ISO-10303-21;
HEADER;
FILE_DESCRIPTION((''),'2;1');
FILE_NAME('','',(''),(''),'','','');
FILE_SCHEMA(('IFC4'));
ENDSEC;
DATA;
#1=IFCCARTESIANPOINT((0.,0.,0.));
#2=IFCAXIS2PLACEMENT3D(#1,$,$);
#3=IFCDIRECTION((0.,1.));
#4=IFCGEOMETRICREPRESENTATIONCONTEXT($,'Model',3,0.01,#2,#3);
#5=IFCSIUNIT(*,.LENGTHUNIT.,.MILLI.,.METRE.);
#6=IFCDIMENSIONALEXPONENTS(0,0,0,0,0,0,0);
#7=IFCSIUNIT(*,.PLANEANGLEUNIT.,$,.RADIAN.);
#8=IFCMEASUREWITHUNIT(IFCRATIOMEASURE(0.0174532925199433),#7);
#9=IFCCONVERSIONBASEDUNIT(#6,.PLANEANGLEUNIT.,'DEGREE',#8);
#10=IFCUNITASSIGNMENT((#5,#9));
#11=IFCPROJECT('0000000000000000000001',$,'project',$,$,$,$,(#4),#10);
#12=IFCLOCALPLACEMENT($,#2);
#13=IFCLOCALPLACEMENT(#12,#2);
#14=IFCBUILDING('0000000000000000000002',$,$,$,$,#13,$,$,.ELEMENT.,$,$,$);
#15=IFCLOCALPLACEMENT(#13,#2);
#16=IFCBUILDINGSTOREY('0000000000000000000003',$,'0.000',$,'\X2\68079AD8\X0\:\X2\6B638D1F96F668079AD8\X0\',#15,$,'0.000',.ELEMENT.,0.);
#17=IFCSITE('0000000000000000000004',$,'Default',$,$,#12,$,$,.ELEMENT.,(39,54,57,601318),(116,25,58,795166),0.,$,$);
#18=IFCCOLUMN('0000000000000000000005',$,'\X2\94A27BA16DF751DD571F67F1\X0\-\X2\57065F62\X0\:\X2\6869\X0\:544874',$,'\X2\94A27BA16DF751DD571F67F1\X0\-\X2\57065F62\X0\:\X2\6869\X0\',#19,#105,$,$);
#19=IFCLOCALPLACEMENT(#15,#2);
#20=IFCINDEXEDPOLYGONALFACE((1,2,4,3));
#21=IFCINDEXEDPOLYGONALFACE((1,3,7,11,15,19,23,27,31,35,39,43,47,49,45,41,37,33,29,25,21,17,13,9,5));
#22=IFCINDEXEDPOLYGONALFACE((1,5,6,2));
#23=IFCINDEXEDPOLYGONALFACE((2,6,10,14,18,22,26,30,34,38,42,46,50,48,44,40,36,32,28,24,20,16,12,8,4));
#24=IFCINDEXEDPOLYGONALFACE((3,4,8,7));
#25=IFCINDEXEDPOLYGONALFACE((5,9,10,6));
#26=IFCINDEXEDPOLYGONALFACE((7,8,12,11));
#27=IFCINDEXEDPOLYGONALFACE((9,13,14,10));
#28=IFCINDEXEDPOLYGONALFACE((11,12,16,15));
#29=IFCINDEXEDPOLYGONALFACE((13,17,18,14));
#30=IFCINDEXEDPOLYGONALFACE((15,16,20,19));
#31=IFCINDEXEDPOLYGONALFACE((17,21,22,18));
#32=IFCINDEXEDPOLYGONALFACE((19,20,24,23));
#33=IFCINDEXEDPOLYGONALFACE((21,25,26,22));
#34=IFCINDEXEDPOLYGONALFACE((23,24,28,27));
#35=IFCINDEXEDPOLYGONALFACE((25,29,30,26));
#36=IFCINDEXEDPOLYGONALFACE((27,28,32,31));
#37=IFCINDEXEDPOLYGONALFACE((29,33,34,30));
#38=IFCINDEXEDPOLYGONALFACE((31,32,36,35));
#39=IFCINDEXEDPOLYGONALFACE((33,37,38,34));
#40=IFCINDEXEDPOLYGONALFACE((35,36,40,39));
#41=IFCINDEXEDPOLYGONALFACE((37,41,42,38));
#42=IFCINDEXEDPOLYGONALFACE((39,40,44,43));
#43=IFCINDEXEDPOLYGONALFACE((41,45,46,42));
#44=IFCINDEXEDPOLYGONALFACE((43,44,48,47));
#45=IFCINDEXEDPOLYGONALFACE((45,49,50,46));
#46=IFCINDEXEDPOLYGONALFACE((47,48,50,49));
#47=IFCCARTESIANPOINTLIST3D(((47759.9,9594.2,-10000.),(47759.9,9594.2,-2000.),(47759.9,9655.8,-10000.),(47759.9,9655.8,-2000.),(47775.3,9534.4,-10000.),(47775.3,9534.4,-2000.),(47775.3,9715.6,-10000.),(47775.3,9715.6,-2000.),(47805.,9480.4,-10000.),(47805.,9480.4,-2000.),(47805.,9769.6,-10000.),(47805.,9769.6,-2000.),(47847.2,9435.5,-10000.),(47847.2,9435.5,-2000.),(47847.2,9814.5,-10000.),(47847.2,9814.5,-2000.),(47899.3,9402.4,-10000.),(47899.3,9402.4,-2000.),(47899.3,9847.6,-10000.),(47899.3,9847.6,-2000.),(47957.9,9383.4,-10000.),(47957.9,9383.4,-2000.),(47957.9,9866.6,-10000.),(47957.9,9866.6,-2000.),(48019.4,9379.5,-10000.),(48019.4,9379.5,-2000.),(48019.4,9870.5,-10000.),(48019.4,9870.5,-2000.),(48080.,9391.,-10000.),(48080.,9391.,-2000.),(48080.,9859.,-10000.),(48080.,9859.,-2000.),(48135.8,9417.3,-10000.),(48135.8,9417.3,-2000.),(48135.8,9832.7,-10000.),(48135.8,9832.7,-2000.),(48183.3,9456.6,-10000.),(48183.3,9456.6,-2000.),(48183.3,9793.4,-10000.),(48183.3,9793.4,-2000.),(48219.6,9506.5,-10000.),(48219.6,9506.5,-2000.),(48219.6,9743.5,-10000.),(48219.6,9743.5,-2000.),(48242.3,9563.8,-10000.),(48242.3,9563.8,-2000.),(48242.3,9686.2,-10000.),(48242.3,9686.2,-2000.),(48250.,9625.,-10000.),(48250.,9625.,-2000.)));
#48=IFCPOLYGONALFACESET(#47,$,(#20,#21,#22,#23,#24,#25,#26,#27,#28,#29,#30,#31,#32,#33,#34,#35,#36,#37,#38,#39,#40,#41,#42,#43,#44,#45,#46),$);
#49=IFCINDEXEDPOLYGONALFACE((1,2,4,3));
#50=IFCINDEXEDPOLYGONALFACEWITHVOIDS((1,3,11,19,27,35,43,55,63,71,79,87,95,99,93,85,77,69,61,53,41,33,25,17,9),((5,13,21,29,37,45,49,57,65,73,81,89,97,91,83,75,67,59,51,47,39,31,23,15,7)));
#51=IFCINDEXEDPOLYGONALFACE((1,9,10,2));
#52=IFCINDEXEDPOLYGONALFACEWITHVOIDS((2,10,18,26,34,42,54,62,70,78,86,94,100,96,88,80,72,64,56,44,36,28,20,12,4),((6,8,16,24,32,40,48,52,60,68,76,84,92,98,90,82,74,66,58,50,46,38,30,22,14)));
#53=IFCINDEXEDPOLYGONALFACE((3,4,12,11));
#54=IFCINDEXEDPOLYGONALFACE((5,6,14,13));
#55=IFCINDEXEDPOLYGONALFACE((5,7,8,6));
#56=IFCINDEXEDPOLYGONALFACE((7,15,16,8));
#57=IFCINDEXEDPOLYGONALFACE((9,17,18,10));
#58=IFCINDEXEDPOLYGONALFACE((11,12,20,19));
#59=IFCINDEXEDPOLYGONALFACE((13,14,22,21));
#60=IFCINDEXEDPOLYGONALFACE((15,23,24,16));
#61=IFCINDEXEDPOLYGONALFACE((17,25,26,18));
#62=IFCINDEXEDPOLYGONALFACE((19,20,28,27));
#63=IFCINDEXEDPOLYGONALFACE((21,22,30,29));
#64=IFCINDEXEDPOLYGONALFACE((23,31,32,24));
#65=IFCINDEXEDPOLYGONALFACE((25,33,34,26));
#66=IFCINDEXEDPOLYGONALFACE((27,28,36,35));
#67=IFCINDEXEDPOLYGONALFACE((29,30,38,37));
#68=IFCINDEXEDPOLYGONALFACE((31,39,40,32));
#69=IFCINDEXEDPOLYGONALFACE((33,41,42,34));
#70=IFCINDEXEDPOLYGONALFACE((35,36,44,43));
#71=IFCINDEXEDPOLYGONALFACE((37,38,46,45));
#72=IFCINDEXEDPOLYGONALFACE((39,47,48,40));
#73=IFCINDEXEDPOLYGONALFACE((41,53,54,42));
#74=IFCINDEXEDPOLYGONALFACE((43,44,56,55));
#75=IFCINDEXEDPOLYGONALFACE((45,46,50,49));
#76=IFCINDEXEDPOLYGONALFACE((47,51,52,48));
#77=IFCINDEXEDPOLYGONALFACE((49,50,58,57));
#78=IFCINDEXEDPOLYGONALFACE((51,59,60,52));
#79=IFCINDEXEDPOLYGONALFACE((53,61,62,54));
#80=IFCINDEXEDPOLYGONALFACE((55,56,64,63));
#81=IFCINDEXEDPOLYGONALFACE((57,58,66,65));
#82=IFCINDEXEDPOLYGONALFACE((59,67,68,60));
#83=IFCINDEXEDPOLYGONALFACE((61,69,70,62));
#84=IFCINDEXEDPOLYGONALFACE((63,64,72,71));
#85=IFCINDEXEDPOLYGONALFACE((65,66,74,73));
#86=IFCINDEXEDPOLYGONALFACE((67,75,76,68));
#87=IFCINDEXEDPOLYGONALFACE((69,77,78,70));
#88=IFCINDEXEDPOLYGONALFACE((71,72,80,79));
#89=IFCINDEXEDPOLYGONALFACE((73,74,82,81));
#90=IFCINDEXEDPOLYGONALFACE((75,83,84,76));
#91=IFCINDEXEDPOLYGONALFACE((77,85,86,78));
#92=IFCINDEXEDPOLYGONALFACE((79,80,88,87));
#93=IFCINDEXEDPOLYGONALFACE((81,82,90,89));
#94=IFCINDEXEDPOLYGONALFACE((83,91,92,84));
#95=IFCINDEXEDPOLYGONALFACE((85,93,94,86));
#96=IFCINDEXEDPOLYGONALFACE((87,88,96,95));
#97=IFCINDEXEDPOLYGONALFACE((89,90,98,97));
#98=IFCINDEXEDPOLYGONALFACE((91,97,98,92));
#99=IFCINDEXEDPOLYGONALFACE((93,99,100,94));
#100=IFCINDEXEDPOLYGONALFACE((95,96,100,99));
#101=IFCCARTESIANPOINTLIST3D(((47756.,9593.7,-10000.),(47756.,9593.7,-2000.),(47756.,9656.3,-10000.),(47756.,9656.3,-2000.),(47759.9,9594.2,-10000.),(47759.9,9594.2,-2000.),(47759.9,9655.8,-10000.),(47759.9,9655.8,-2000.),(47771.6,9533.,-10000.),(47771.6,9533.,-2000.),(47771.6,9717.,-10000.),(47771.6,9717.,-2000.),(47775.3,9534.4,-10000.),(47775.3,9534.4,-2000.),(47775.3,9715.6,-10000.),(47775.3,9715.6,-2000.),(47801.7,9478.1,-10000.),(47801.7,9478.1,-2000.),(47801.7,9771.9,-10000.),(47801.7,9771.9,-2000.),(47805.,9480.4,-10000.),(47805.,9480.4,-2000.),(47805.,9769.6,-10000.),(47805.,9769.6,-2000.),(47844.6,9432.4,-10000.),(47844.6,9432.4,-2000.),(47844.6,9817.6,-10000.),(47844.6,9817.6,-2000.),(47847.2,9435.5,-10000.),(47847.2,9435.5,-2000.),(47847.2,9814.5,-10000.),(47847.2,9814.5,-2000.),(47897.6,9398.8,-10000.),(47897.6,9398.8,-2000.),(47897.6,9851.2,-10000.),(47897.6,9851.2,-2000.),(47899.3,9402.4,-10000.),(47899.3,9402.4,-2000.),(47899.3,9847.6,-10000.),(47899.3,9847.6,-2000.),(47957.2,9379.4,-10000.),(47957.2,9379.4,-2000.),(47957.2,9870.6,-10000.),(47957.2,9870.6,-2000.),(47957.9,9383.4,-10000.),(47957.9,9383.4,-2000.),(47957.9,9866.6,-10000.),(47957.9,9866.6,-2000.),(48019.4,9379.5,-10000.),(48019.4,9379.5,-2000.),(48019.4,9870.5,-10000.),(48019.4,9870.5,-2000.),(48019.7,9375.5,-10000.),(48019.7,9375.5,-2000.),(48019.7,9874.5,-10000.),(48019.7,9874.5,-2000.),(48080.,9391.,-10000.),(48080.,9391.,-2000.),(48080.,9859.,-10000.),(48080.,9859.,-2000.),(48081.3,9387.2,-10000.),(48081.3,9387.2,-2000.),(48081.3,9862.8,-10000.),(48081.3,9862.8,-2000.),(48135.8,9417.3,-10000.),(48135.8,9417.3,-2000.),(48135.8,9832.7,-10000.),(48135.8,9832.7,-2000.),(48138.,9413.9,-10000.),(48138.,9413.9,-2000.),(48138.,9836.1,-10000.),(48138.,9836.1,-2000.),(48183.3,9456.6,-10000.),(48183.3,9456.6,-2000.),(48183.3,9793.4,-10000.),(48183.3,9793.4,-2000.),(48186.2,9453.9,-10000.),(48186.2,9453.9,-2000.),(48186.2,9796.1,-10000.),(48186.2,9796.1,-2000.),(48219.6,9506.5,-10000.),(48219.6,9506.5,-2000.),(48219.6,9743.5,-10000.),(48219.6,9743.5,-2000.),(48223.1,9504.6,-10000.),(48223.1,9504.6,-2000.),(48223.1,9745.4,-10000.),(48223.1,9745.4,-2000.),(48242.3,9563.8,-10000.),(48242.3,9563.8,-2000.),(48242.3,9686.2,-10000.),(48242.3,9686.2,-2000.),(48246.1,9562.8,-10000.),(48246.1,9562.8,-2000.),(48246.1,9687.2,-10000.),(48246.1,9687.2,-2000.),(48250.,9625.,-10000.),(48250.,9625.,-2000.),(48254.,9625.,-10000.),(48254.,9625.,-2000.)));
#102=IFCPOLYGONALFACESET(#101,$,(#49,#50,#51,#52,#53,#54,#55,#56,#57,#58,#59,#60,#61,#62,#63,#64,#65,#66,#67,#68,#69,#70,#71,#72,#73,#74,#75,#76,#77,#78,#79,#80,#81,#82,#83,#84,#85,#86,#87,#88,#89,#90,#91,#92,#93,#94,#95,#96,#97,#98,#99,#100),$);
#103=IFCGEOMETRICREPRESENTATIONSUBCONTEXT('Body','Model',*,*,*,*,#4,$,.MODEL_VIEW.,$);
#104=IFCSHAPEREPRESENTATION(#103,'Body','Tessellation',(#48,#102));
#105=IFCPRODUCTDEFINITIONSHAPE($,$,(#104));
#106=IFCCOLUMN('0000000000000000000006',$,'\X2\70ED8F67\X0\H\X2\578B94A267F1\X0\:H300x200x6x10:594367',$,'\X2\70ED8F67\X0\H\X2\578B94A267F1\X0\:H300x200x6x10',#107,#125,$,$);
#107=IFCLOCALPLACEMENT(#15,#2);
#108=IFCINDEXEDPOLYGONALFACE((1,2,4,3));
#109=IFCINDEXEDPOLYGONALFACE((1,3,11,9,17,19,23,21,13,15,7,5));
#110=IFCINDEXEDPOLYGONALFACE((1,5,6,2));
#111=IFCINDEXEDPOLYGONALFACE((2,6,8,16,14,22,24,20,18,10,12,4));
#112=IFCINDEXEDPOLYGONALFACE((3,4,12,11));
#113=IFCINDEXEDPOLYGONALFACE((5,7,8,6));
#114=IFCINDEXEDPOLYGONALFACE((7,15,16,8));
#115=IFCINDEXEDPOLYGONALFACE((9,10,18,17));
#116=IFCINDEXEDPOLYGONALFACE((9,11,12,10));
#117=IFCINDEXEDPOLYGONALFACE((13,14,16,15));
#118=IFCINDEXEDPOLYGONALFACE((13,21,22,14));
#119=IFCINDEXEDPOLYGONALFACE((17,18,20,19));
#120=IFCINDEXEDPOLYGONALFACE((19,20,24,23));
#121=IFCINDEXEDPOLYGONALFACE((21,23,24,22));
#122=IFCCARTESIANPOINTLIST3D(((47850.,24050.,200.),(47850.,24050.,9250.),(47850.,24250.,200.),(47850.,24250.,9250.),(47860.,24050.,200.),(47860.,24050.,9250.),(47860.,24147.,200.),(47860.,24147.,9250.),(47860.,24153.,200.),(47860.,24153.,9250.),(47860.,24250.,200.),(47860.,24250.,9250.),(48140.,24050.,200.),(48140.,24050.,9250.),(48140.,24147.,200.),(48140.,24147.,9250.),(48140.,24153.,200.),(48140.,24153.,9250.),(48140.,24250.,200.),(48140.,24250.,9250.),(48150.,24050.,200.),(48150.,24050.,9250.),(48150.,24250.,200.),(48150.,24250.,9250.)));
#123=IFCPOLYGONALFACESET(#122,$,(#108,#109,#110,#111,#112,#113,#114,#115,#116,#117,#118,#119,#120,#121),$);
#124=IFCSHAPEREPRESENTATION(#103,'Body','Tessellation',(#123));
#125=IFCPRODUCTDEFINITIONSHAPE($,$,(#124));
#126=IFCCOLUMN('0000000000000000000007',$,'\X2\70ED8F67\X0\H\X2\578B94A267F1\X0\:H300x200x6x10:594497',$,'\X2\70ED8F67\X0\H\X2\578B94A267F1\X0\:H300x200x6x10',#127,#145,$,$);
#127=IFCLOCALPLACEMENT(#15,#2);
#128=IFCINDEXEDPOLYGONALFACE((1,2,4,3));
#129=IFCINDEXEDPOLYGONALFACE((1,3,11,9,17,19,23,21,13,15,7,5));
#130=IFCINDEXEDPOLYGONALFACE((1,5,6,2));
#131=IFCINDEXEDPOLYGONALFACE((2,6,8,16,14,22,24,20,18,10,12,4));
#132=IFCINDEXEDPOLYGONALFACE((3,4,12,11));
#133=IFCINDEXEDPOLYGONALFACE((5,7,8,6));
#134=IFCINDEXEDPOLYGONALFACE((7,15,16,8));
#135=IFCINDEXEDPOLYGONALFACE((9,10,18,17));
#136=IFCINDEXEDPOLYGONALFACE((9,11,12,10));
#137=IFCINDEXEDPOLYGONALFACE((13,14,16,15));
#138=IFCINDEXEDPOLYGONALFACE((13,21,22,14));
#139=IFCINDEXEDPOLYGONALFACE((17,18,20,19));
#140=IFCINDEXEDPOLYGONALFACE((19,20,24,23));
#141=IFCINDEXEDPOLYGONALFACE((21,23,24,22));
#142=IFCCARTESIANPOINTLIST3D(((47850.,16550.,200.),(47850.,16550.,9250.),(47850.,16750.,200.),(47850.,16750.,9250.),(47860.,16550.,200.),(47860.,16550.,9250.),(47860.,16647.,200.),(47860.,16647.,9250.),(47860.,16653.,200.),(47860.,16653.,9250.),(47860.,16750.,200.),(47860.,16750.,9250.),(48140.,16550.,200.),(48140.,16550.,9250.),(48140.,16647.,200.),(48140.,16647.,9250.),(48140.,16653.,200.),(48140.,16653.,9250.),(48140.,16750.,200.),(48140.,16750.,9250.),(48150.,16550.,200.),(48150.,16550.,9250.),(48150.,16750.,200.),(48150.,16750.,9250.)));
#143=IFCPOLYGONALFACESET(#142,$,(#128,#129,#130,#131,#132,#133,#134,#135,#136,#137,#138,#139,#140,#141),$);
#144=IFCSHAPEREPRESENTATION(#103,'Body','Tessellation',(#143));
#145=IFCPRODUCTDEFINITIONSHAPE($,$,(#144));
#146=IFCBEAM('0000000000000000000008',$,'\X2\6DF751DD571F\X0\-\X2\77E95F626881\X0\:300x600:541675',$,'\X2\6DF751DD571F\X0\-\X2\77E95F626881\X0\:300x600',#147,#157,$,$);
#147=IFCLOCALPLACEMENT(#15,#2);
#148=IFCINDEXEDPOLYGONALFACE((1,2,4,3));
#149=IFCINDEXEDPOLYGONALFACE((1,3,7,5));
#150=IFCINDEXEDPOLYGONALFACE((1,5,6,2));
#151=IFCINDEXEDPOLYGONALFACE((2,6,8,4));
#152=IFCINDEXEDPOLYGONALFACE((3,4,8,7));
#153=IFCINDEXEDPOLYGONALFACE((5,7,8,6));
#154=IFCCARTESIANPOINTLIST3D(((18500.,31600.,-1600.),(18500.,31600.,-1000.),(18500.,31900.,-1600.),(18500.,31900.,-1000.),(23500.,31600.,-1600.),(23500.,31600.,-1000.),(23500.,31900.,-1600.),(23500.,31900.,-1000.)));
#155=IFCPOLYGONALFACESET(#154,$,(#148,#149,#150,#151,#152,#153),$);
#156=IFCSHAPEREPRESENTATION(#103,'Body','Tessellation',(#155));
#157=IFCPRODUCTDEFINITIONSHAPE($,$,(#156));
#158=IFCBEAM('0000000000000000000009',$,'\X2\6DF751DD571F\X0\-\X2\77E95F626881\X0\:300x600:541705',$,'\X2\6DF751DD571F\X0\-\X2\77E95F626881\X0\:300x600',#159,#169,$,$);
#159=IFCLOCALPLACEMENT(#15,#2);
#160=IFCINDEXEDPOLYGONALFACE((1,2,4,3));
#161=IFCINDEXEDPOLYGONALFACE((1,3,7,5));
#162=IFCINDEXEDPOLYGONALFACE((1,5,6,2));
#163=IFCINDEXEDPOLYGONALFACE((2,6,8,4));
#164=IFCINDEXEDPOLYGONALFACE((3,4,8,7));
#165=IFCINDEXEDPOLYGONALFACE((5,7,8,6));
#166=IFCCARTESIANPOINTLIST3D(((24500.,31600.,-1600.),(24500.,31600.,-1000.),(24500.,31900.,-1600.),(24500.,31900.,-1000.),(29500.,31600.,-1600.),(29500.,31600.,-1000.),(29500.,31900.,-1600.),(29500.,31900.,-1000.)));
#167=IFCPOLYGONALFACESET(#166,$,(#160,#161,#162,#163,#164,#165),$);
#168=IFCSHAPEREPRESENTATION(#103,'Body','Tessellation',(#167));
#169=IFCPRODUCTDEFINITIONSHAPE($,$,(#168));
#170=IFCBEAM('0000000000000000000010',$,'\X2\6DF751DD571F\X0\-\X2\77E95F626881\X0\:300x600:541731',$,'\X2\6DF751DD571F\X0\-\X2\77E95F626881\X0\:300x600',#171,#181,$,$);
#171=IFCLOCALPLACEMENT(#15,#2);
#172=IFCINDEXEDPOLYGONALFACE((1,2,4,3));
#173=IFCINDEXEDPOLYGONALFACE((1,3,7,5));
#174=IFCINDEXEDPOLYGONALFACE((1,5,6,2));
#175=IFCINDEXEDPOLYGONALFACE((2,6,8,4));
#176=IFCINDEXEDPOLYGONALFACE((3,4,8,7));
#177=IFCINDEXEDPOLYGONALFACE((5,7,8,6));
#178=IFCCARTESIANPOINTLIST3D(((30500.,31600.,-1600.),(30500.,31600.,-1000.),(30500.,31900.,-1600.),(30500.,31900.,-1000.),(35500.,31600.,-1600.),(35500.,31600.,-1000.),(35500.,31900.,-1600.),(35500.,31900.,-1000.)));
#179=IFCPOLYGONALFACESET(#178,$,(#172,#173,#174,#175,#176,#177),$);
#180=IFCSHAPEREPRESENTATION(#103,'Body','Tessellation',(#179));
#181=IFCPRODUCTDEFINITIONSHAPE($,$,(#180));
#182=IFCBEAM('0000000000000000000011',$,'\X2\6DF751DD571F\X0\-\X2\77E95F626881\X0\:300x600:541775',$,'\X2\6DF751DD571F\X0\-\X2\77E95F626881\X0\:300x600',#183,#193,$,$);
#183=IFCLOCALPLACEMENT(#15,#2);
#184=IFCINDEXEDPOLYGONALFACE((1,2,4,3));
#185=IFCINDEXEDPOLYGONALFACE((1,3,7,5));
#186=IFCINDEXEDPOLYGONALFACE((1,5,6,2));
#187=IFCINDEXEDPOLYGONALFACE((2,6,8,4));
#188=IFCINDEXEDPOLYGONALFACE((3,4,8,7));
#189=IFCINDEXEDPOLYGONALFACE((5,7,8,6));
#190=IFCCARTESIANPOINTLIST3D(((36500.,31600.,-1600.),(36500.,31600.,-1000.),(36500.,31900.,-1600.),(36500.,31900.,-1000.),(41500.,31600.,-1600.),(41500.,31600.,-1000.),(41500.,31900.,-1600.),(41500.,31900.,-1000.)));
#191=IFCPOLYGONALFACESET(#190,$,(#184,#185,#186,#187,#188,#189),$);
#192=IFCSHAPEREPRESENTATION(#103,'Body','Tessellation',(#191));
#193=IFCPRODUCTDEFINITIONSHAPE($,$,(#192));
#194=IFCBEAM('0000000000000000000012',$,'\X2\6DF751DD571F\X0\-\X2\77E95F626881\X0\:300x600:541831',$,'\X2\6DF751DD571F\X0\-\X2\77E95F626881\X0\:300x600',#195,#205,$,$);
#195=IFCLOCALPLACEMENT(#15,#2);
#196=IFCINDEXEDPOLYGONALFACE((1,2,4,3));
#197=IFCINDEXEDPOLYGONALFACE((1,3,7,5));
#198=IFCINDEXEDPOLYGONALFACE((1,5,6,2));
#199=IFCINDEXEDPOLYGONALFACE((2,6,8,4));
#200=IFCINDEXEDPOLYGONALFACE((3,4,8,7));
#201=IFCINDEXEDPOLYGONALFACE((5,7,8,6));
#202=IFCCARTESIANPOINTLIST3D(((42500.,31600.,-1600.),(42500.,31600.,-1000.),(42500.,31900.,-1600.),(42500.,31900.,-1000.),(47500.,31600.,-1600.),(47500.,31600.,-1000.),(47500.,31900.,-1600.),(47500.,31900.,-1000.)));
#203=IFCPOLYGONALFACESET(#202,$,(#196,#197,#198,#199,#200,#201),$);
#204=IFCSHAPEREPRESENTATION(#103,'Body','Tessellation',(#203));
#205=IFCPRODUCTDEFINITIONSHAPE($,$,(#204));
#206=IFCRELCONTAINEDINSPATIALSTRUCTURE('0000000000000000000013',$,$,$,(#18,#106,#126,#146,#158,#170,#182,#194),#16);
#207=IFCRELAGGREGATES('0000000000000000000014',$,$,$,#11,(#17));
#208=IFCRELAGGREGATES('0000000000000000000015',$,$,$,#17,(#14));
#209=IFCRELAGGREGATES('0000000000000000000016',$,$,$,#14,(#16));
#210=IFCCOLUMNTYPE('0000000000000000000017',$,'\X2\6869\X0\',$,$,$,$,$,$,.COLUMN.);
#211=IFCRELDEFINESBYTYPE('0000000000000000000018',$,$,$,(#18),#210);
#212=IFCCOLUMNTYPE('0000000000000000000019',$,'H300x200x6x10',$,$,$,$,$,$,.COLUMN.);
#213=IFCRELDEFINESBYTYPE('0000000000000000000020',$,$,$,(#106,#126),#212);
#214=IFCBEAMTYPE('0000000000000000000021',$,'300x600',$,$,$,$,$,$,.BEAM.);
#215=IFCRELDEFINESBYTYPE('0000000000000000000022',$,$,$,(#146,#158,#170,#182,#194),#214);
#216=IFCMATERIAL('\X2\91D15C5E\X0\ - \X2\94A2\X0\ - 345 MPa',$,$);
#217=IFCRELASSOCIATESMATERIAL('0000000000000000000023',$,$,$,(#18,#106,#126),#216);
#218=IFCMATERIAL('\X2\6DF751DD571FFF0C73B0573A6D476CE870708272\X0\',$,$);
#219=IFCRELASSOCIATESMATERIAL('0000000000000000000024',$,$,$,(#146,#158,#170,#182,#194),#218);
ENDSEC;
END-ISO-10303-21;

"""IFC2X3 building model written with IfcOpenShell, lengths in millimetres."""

from ifc_helpers import new_model, entity, si_unit, converted_unit, direction, frame, frame_2d, origin, place, context, subcontext, project, spatial, polyline, rectangle, circle, hollow_circle, outline, extrude, source, transform, mapped, material, type_object, type_shapes, element, save


model = new_model("IFC2X3")

# Units and contexts
model_context = context("Model", 3, precision=0.01, world=origin(), true_north=direction((0.0, 1.0)))
body_context = subcontext(model_context, "Body", "Model", "MODEL_VIEW")
ifc_project = project(units=[si_unit("LENGTHUNIT", "METRE", prefix="MILLI"), converted_unit("PLANEANGLEUNIT", "DEGREE", entity("IfcRatioMeasure", 0.0174532925199433), si_unit("PLANEANGLEUNIT", "RADIAN"), dimensions=[0, 0, 0, 0, 0, 0, 0])], contexts=[model_context])

# Site, building, storey
site_placement = place(None, origin())
site = spatial("IfcSite", under=ifc_project, at=site_placement, Name="Default", CompositionType="ELEMENT", RefLatitude=(39, 54, 57, 601318), RefLongitude=(116, 25, 58, 795166), RefElevation=0.0)
building_placement = place(site_placement, origin())
building = spatial("IfcBuilding", under=site, at=building_placement, CompositionType="ELEMENT")
storey_placement = place(building_placement, origin())
storey = spatial("IfcBuildingStorey", under=building, at=storey_placement, Name="0.000", ObjectType="标高:正负零标高", LongName="0.000", CompositionType="ELEMENT", Elevation=0.0)

# Columns
ifc_material_1 = material(Name="金属 - 钢 - 345 MPa")
column_type_1 = type_object("IfcColumnType", Name="桩", PredefinedType="COLUMN")
shared_shape_1 = source(origin(), body_context, "Body", "SweptSolid", [
    extrude(circle(Radius=246.0, at=frame_2d((0.0, 0.0), x_axis=(1.0, 0.0))), frame((0.0, 0.0, -10000.0)), (0.0, 0.0, 1.0), 8000.0),
    extrude(hollow_circle(Radius=250.0, WallThickness=4.0, at=frame_2d((0.0, 0.0), x_axis=(1.0, 0.0))), frame((0.0, 0.0, -10000.0)), (0.0, 0.0, 1.0), 8000.0),
])
type_shapes(column_type_1, [shared_shape_1])
for number, where, name in (
    (1, (48004.0, 9625.0, 0.0), "钢管混凝土柱-圆形:桩:544874"),
):
    element("IfcColumn", number, at=place(storey_placement, frame(where)), inside=storey, type_object=column_type_1, material=ifc_material_1, Name=name, ObjectType="钢管混凝土柱-圆形:桩", context=body_context, shape_type="MappedRepresentation", body=[
        mapped(shared_shape_1, transform((0.0, 0.0, 0.0), scale=1.0)),
    ])
column_type_2 = type_object("IfcColumnType", Name="H300x200x6x10", PredefinedType="COLUMN")
shared_shape_2 = source(origin(), body_context, "Body", "SweptSolid", [
    extrude(outline(polyline([(140.0, -100.0), (150.0, -100.0), (150.0, 100.0), (140.0, 100.0), (140.0, 3.0), (-140.0, 3.0), (-140.0, 100.0), (-150.0, 100.0), (-150.0, -100.0), (-140.0, -100.0), (-140.0, -3.0), (140.0, -3.0), (140.0, -100.0)])), frame((0.0, 0.0, 200.0), z_axis=(0.0, 0.0, 1.0), x_axis=(0.0, -1.0, 0.0)), (0.0, 0.0, 1.0), 9050.0),
])
type_shapes(column_type_2, [shared_shape_2])
for number, where, z_axis, x_axis, name in (
    (2, (48000.0, 24150.0, 0.0), (0.0, 0.0, 1.0), (0.0, 1.0, 0.0), "热轧H型钢柱:H300x200x6x10:594367"),
    (3, (48000.0, 16650.0, 0.0), (0.0, 0.0, 1.0), (0.0, 1.0, 0.0), "热轧H型钢柱:H300x200x6x10:594497"),
):
    element("IfcColumn", number, at=place(storey_placement, frame(where, z_axis=z_axis, x_axis=x_axis)), inside=storey, type_object=column_type_2, material=ifc_material_1, Name=name, ObjectType="热轧H型钢柱:H300x200x6x10", context=body_context, shape_type="MappedRepresentation", body=[
        mapped(shared_shape_2, transform((0.0, 0.0, 0.0), scale=1.0)),
    ])

# Beams
ifc_material_2 = material(Name="混凝土，现场浇注灰色")
beam_type_1 = type_object("IfcBeamType", Name="300x600", PredefinedType="BEAM")
for number, where, name in (
    (4, (18500.0, 31900.0, 0.0), "混凝土-矩形梁:300x600:541675"),
    (5, (24500.0, 31900.0, 0.0), "混凝土-矩形梁:300x600:541705"),
):
    element("IfcBeam", number, at=place(storey_placement, frame(where)), inside=storey, type_object=beam_type_1, material=ifc_material_2, Name=name, ObjectType="混凝土-矩形梁:300x600", context=body_context, shape_type="SweptSolid", body=[
        extrude(rectangle(XDim=600.0, YDim=300.0, at=frame_2d((0.0, 0.0), x_axis=(1.0, 0.0))), frame((0.0, -150.0, -1300.0), z_axis=(1.0, 0.0, 0.0), x_axis=(0.0, 0.0, -1.0)), (0.0, 0.0, 1.0), 5000.0),
    ])
beam_1_placement = place(storey_placement, frame((30500.0, 31900.0, 0.0)))
element("IfcBeam", 6, at=beam_1_placement, inside=storey, type_object=beam_type_1, material=ifc_material_2, Name="混凝土-矩形梁:300x600:541731", ObjectType="混凝土-矩形梁:300x600", context=body_context, shape_type="SweptSolid", body=[
    extrude(rectangle(XDim=600.0, YDim=300.0, at=frame_2d((0.0, 0.0), x_axis=(1.0, 0.0))), frame((0.0, -150.0, -1300.0), z_axis=(1.0, 0.0, 0.0), x_axis=(0.0, 0.0, -1.0)), (0.0, 0.0, 1.0), 5000.0),
])
for number, where, name in (
    (7, (36500.0, 31900.0, 0.0), "混凝土-矩形梁:300x600:541775"),
    (8, (42500.0, 31900.0, 0.0), "混凝土-矩形梁:300x600:541831"),
):
    element("IfcBeam", number, at=place(storey_placement, frame(where)), inside=storey, type_object=beam_type_1, material=ifc_material_2, Name=name, ObjectType="混凝土-矩形梁:300x600", context=body_context, shape_type="SweptSolid", body=[
        extrude(rectangle(XDim=600.0, YDim=300.0, at=frame_2d((0.0, 0.0), x_axis=(1.0, 0.0))), frame((0.0, -150.0, -1300.0), z_axis=(1.0, 0.0, 0.0), x_axis=(0.0, 0.0, -1.0)), (0.0, 0.0, 1.0), 5000.0),
    ])

save(model, "model.ifc")
